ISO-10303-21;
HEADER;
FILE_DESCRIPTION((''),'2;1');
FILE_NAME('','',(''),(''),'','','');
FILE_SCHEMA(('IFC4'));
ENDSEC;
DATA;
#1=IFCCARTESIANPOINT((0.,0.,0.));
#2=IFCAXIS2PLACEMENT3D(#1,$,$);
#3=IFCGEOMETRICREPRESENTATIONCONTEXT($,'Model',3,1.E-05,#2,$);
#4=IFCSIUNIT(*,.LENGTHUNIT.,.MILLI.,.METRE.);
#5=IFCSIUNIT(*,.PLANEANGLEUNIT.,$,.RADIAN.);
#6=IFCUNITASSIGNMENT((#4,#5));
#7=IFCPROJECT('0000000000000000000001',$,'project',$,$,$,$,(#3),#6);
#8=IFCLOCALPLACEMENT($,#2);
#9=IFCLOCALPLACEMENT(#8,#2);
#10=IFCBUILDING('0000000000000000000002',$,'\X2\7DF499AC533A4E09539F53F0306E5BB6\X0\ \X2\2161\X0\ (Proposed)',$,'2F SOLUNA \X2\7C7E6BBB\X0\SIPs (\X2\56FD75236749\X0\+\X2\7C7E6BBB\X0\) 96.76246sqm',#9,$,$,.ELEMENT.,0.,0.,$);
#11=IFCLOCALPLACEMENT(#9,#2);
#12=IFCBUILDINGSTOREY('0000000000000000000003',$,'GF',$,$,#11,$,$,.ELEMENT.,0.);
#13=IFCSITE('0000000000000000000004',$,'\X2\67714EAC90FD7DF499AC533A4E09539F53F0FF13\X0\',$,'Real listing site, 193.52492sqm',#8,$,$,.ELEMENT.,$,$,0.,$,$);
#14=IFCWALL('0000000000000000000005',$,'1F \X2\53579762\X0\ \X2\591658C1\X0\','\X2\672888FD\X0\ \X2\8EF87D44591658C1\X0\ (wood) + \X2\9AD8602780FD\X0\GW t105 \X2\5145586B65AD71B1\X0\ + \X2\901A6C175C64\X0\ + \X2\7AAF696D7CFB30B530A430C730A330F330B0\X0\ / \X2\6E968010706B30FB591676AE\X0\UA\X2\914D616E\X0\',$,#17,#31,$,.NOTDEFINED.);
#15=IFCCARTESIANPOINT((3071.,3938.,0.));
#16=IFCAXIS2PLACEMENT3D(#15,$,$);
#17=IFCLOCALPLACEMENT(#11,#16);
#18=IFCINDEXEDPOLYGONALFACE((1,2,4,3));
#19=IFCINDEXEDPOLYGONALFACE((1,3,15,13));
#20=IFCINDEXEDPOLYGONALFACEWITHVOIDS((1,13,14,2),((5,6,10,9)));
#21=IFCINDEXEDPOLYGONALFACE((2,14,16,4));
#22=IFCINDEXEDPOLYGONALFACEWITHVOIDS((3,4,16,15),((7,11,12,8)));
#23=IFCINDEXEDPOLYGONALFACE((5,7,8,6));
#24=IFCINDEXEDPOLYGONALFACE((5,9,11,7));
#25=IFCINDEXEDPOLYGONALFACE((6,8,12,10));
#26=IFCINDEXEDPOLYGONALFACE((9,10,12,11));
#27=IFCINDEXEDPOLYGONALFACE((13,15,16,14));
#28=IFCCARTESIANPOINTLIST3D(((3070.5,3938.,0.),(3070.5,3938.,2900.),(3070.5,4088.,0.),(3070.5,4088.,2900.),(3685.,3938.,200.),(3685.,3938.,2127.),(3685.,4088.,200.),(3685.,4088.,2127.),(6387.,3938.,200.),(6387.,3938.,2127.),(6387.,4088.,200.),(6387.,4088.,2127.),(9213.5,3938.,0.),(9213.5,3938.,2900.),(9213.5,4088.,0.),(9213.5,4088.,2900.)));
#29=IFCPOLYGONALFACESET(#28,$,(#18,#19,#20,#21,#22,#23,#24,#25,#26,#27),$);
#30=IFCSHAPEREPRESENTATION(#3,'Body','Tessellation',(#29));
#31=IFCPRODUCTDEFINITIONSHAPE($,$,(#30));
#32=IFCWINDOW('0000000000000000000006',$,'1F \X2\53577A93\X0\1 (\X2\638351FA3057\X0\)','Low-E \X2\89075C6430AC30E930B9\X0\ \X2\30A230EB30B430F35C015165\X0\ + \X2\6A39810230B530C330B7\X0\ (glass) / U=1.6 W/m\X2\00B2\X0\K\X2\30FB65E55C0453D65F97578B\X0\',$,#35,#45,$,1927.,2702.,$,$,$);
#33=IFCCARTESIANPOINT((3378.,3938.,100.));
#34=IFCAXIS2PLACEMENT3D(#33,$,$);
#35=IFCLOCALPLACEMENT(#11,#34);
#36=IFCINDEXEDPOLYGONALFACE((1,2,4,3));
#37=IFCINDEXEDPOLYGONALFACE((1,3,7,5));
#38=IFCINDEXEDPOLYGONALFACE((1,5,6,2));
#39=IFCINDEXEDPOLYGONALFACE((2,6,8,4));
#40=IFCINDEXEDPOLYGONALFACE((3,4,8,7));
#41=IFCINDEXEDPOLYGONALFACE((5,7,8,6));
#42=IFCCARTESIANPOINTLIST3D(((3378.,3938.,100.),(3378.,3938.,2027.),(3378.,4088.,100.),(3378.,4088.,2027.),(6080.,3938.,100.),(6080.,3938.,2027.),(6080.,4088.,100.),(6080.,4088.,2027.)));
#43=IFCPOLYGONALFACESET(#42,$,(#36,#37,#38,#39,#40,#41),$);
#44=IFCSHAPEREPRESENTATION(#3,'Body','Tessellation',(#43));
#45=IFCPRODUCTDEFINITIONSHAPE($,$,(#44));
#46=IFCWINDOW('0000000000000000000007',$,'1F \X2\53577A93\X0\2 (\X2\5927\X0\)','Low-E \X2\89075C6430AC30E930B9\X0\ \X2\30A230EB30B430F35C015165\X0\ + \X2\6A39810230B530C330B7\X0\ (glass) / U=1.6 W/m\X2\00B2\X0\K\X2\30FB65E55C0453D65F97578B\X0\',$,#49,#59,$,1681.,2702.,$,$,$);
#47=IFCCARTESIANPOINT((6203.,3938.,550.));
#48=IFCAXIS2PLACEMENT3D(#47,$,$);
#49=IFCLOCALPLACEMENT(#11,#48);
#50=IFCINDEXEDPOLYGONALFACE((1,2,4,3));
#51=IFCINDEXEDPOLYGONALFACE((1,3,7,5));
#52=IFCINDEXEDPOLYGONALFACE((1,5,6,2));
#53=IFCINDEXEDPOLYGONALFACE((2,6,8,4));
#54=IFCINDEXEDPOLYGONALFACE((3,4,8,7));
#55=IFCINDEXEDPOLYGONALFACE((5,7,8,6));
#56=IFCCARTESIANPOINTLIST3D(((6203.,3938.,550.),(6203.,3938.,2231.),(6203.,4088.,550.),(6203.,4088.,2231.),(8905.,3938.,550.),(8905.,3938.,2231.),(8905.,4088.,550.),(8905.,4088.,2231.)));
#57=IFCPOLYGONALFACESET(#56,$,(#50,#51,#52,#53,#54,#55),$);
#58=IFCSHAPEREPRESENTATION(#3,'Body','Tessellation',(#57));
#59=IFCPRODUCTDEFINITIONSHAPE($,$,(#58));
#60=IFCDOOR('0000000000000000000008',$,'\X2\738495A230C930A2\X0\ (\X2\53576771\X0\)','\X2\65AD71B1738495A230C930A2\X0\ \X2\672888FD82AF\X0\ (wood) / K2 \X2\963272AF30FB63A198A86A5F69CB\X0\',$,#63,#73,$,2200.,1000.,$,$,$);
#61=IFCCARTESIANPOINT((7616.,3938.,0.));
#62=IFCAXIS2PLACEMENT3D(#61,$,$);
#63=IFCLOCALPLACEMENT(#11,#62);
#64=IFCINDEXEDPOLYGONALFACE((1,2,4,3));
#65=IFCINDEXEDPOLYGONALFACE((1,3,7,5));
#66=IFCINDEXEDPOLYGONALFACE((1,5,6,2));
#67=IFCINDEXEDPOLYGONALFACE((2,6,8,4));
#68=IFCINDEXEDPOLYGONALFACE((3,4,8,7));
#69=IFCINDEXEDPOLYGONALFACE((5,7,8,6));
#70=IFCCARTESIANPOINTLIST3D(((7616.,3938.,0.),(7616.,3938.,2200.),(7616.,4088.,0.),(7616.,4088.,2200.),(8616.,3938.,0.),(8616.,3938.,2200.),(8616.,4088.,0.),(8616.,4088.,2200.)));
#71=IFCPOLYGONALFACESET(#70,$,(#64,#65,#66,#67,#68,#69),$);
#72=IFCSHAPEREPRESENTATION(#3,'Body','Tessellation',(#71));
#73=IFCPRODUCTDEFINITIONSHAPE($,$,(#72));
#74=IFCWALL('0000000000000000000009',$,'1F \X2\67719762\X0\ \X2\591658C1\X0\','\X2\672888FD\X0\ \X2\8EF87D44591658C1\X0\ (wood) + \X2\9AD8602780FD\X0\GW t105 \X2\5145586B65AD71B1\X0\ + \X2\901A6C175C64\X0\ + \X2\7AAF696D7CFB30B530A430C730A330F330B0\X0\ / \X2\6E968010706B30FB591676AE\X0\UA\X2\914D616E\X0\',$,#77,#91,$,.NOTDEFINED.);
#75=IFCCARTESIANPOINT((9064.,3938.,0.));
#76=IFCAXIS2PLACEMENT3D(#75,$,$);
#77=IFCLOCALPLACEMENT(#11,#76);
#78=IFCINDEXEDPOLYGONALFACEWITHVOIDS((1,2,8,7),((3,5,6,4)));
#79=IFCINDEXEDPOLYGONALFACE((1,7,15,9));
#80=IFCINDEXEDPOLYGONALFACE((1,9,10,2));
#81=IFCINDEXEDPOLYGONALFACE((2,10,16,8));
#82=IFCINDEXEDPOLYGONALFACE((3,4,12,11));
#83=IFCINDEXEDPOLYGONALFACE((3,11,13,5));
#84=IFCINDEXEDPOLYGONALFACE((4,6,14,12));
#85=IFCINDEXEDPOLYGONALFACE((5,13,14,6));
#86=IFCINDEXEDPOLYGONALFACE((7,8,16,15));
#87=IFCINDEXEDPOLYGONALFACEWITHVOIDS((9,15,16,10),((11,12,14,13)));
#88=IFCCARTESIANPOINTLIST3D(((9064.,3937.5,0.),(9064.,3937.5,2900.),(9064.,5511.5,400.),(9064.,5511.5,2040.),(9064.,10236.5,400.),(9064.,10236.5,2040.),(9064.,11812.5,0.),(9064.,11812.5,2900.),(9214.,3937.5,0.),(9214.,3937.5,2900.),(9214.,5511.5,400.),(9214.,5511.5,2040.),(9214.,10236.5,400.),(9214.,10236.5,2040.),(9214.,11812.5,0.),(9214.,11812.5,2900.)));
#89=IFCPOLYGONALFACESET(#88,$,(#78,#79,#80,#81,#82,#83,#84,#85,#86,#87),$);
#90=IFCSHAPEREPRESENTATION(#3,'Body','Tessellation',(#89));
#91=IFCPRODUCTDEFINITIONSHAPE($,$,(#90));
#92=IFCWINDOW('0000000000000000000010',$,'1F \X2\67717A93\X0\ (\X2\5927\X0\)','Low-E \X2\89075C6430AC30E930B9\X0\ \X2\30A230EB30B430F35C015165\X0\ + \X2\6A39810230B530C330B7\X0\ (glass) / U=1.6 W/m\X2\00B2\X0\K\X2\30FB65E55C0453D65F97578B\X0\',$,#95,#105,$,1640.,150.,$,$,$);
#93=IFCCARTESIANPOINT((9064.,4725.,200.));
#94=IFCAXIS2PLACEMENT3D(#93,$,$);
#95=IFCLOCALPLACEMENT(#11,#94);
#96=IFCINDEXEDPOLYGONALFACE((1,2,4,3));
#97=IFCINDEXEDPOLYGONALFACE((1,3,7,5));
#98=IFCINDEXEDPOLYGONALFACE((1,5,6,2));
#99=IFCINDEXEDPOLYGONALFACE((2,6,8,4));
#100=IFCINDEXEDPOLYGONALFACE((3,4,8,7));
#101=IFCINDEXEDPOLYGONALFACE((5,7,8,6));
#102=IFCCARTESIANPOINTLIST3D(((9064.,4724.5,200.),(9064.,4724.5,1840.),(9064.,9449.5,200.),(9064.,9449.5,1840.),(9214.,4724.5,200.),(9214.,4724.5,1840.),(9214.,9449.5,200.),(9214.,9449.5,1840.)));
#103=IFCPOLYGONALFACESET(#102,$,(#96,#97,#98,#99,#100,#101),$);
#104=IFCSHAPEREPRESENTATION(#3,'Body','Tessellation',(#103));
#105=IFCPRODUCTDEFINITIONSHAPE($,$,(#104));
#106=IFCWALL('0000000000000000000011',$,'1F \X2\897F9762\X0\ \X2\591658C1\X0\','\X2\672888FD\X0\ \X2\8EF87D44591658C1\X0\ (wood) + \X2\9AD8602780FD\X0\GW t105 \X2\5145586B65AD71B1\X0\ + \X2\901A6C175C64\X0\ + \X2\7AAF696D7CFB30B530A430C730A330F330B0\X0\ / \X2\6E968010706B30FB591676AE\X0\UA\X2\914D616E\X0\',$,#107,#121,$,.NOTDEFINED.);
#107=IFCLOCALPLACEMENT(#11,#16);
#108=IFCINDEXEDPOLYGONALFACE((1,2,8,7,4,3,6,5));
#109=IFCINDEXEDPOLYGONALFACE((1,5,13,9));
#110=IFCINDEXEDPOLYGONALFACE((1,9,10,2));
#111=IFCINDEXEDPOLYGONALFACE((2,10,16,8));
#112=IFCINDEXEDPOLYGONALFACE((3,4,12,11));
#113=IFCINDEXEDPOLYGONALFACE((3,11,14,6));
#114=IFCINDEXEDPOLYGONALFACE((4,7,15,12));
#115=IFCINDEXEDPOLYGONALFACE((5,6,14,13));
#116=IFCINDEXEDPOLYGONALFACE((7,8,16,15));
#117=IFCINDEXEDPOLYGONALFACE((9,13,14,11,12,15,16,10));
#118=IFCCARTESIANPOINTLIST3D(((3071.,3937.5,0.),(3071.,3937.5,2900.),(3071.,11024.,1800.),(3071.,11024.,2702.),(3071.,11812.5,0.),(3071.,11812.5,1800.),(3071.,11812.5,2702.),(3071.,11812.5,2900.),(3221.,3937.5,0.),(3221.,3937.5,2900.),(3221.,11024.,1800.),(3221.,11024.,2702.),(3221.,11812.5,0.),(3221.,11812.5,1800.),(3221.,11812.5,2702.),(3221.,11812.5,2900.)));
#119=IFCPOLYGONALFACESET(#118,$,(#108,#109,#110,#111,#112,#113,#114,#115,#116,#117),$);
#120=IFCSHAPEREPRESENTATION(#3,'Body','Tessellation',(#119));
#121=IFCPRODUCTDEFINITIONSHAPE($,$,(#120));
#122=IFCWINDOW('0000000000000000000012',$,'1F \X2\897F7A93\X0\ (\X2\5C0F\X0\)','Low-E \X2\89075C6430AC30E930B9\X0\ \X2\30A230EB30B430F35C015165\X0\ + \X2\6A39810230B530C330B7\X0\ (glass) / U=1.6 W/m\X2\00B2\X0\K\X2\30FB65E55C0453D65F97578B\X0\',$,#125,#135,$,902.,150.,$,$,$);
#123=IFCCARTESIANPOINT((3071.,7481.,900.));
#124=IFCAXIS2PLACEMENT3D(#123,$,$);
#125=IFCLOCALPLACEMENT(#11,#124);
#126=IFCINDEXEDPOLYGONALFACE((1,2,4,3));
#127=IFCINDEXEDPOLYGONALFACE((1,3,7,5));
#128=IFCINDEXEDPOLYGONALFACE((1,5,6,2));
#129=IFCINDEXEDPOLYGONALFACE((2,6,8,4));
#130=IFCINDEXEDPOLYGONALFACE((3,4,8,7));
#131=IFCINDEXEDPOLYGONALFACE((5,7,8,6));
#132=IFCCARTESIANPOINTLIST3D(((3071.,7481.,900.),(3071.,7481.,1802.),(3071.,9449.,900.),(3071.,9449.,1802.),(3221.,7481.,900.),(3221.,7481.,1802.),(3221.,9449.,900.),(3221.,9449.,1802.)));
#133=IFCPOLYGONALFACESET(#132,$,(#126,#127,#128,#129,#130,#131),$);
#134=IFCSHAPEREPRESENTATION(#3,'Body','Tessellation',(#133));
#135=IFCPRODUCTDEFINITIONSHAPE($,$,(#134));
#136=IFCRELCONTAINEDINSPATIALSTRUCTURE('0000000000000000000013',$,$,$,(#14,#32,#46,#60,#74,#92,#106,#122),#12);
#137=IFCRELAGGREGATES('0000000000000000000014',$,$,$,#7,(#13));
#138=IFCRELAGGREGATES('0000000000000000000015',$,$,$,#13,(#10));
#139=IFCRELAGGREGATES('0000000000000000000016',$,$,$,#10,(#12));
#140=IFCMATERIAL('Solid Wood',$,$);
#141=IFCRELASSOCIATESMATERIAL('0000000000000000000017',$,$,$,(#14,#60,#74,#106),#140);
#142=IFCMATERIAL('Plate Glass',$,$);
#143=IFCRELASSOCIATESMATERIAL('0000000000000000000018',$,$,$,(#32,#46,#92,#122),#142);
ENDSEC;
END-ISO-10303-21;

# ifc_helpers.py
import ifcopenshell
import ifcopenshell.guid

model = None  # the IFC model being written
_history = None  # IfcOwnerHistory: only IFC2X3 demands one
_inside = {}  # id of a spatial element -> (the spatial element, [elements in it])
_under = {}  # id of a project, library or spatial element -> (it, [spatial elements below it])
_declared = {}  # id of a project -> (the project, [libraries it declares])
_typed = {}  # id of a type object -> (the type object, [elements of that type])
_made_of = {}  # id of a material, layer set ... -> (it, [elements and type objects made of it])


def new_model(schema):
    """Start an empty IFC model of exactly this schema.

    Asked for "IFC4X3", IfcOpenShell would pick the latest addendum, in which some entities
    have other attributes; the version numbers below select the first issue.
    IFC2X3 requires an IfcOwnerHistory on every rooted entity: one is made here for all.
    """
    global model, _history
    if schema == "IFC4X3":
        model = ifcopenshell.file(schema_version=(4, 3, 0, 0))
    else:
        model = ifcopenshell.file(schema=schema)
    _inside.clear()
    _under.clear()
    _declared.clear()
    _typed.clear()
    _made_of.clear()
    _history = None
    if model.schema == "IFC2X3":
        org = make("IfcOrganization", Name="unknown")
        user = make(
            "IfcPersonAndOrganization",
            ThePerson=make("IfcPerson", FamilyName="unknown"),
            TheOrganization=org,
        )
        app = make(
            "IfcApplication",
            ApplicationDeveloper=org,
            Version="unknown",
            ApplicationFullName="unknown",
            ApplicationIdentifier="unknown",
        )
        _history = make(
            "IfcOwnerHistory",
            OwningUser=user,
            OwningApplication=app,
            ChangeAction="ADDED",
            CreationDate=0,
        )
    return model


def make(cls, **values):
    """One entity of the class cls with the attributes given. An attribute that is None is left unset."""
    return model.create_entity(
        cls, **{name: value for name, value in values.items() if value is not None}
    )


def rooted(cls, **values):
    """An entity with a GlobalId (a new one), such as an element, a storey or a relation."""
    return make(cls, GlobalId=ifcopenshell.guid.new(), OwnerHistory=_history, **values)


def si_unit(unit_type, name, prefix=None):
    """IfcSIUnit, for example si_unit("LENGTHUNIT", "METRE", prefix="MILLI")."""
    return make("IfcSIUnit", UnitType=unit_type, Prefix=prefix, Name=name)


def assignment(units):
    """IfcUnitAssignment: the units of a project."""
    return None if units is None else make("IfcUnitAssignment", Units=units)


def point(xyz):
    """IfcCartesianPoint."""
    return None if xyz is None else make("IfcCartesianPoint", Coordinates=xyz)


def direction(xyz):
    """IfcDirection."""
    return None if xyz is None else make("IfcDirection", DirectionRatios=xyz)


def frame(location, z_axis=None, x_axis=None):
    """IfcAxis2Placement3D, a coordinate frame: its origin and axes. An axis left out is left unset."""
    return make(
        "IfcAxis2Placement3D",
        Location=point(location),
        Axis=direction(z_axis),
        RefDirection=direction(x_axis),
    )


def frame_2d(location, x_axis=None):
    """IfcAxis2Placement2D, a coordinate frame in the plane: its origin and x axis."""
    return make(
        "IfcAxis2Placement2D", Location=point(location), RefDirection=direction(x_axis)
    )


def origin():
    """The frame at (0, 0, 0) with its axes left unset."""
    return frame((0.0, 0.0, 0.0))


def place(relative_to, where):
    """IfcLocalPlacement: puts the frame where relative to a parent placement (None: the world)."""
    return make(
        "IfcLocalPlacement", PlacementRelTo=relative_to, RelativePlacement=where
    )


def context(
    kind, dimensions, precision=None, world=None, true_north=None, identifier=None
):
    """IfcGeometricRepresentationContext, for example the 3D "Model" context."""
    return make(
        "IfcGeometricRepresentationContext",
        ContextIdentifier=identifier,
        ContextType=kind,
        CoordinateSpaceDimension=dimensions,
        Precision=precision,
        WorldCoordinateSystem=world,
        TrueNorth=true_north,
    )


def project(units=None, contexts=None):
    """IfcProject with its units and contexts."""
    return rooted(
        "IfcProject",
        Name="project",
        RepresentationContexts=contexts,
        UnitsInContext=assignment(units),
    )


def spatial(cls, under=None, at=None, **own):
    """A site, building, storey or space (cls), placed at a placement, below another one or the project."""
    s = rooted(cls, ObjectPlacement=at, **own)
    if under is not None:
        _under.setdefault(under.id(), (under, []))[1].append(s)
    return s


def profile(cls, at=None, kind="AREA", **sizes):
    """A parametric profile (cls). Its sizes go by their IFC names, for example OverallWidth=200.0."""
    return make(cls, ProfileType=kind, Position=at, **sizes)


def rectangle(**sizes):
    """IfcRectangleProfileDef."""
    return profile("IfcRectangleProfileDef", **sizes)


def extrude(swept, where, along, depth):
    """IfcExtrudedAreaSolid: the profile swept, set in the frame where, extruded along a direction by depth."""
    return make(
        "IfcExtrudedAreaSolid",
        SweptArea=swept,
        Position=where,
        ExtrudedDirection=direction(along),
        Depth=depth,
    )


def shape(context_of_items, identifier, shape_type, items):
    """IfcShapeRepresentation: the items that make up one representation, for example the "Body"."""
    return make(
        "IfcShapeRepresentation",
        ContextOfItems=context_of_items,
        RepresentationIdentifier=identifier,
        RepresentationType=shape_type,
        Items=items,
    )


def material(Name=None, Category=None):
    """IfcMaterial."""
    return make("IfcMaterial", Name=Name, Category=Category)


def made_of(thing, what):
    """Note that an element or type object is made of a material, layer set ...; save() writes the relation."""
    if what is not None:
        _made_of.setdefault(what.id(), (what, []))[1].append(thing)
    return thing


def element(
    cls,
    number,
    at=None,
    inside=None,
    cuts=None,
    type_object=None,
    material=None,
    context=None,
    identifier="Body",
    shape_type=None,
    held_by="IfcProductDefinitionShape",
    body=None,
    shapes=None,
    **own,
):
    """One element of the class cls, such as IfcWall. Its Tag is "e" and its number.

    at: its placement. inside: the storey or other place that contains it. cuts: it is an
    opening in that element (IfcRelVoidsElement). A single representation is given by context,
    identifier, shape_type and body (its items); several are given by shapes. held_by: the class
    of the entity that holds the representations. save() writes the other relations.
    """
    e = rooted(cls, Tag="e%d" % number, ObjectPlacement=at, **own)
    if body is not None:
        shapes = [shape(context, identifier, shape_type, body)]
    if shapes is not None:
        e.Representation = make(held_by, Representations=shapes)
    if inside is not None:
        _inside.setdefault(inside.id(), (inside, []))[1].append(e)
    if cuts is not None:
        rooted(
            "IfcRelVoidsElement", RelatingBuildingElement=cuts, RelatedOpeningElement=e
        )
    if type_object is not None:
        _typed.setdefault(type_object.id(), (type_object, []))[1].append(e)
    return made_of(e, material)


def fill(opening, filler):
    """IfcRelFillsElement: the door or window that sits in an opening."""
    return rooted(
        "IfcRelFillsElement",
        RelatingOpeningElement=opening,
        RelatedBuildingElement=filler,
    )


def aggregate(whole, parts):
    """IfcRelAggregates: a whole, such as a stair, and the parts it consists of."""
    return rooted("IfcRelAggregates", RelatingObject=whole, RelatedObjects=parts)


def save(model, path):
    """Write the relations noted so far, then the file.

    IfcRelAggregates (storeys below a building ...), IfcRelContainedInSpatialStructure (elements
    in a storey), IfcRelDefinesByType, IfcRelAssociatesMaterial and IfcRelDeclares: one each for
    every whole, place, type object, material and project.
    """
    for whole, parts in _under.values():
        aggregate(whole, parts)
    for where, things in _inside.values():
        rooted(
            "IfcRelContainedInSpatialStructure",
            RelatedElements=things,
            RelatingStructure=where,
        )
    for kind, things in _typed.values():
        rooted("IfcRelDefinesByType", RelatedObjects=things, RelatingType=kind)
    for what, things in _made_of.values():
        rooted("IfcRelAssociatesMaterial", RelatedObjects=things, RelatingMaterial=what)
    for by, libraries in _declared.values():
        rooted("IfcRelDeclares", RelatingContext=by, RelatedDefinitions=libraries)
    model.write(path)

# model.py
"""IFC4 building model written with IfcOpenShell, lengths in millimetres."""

from ifc_helpers import new_model, si_unit, frame, frame_2d, origin, place, context, project, spatial, rectangle, extrude, material, element, fill, save


model = new_model("IFC4")

# Units and contexts
model_context = context("Model", 3, precision=1e-05, world=origin())
ifc_project = project(units=[si_unit("LENGTHUNIT", "METRE", prefix="MILLI"), si_unit("PLANEANGLEUNIT", "RADIAN")], contexts=[model_context])

# Site, building, storey
site_placement = place(None, origin())
site = spatial("IfcSite", under=ifc_project, at=site_placement, Name="東京都練馬区三原台３", ObjectType="Real listing site, 193.52492sqm", CompositionType="ELEMENT", RefElevation=0.0)
building_placement = place(site_placement, origin())
building = spatial("IfcBuilding", under=site, at=building_placement, Name="練馬区三原台の家 Ⅱ (Proposed)", ObjectType="2F SOLUNA 籾殻SIPs (国産杉+籾殻) 96.76246sqm", CompositionType="ELEMENT", ElevationOfRefHeight=0.0, ElevationOfTerrain=0.0)
storey_placement = place(building_placement, origin())
storey = spatial("IfcBuildingStorey", under=building, at=storey_placement, Name="GF", CompositionType="ELEMENT", Elevation=0.0)

# Shared definitions
ifc_material_1 = material(Name="Solid Wood")

# Wall, openings, windows, door
wall_1_placement = place(storey_placement, frame((3071.0, 3938.0, 0.0)))
wall_1 = element("IfcWall", 1, at=wall_1_placement, inside=storey, material=ifc_material_1, Name="1F 南面 外壁", Description="木製 軸組外壁 (wood) + 高性能GW t105 充填断熱 + 通気層 + 窯業系サイディング / 準耐火・外皮UA配慮", PredefinedType="NOTDEFINED", context=model_context, shape_type="SweptSolid", body=[
    extrude(rectangle(XDim=6143.0, YDim=150.0, at=frame_2d((3071.0, 75.0))), frame((3071.0, 3938.0, 0.0)), (0.0, 0.0, 1.0), 2900.0),
])
opening_1_placement = place(storey_placement, frame((3378.0, 3938.0, 100.0)))
opening_1 = element("IfcOpeningElement", 2, at=opening_1_placement, cuts=wall_1, PredefinedType="NOTDEFINED", context=model_context, shape_type="SweptSolid", body=[
    extrude(rectangle(XDim=2702.0, YDim=150.0, at=frame_2d((1351.0, 75.0))), frame((3378.0, 3938.0, 100.0)), (0.0, 0.0, 1.0), 1927.0),
])
opening_2_placement = place(storey_placement, frame((6203.0, 3938.0, 550.0)))
opening_2 = element("IfcOpeningElement", 3, at=opening_2_placement, cuts=wall_1, PredefinedType="NOTDEFINED", context=model_context, shape_type="SweptSolid", body=[
    extrude(rectangle(XDim=2702.0, YDim=150.0, at=frame_2d((1351.0, 75.0))), frame((6203.0, 3938.0, 550.0)), (0.0, 0.0, 1.0), 1681.0),
])
opening_3_placement = place(storey_placement, frame((7616.0, 3938.0, 0.0)))
opening_3 = element("IfcOpeningElement", 4, at=opening_3_placement, cuts=wall_1, PredefinedType="NOTDEFINED", context=model_context, shape_type="SweptSolid", body=[
    extrude(rectangle(XDim=1000.0, YDim=150.0, at=frame_2d((500.0, 75.0))), frame((7616.0, 3938.0, 0.0)), (0.0, 0.0, 1.0), 2200.0),
])
ifc_material_2 = material(Name="Plate Glass")
window_1_placement = place(storey_placement, frame((3378.0, 3938.0, 100.0)))
window_1 = element("IfcWindow", 5, at=window_1_placement, inside=storey, material=ifc_material_2, Name="1F 南窓1 (掃出し)", Description="Low-E 複層ガラス アルゴン封入 + 樹脂サッシ (glass) / U=1.6 W/m²K・日射取得型", OverallHeight=1927.0, OverallWidth=2702.0, context=model_context, shape_type="SweptSolid", body=[
    extrude(rectangle(XDim=2702.0, YDim=150.0, at=frame_2d((1351.0, 75.0))), frame((3378.0, 3938.0, 100.0)), (0.0, 0.0, 1.0), 1927.0),
])
fill(opening_1, window_1)
window_2_placement = place(storey_placement, frame((6203.0, 3938.0, 550.0)))
window_2 = element("IfcWindow", 6, at=window_2_placement, inside=storey, material=ifc_material_2, Name="1F 南窓2 (大)", Description="Low-E 複層ガラス アルゴン封入 + 樹脂サッシ (glass) / U=1.6 W/m²K・日射取得型", OverallHeight=1681.0, OverallWidth=2702.0, context=model_context, shape_type="SweptSolid", body=[
    extrude(rectangle(XDim=2702.0, YDim=150.0, at=frame_2d((1351.0, 75.0))), frame((6203.0, 3938.0, 550.0)), (0.0, 0.0, 1.0), 1681.0),
])
fill(opening_2, window_2)
door_placement = place(storey_placement, frame((7616.0, 3938.0, 0.0)))
door = element("IfcDoor", 7, at=door_placement, inside=storey, material=ifc_material_1, Name="玄関ドア (南東)", Description="断熱玄関ドア 木製芯 (wood) / K2 防犯・採風機構", OverallHeight=2200.0, OverallWidth=1000.0, context=model_context, shape_type="SweptSolid", body=[
    extrude(rectangle(XDim=1000.0, YDim=150.0, at=frame_2d((500.0, 75.0))), frame((7616.0, 3938.0, 0.0)), (0.0, 0.0, 1.0), 2200.0),
])
fill(opening_3, door)

# Walls, openings, windows
wall_2_placement = place(storey_placement, frame((9064.0, 3938.0, 0.0)))
wall_2 = element("IfcWall", 8, at=wall_2_placement, inside=storey, material=ifc_material_1, Name="1F 東面 外壁", Description="木製 軸組外壁 (wood) + 高性能GW t105 充填断熱 + 通気層 + 窯業系サイディング / 準耐火・外皮UA配慮", PredefinedType="NOTDEFINED", context=model_context, shape_type="SweptSolid", body=[
    extrude(rectangle(XDim=150.0, YDim=7875.0, at=frame_2d((75.0, 3937.0))), frame((9064.0, 3938.0, 0.0)), (0.0, 0.0, 1.0), 2900.0),
])
opening_4_placement = place(storey_placement, frame((9064.0, 4725.0, 200.0)))
opening_4 = element("IfcOpeningElement", 9, at=opening_4_placement, cuts=wall_2, PredefinedType="NOTDEFINED", context=model_context, shape_type="SweptSolid", body=[
    extrude(rectangle(XDim=150.0, YDim=4725.0, at=frame_2d((75.0, 2362.0))), frame((9064.0, 4725.0, 200.0)), (0.0, 0.0, 1.0), 1640.0),
])
window_3_placement = place(storey_placement, frame((9064.0, 4725.0, 200.0)))
window_3 = element("IfcWindow", 10, at=window_3_placement, inside=storey, material=ifc_material_2, Name="1F 東窓 (大)", Description="Low-E 複層ガラス アルゴン封入 + 樹脂サッシ (glass) / U=1.6 W/m²K・日射取得型", OverallHeight=1640.0, OverallWidth=150.0, context=model_context, shape_type="SweptSolid", body=[
    extrude(rectangle(XDim=150.0, YDim=4725.0, at=frame_2d((75.0, 2362.0))), frame((9064.0, 4725.0, 200.0)), (0.0, 0.0, 1.0), 1640.0),
])
fill(opening_4, window_3)
wall_3_placement = place(storey_placement, frame((3071.0, 3938.0, 0.0)))
wall_3 = element("IfcWall", 11, at=wall_3_placement, inside=storey, material=ifc_material_1, Name="1F 西面 外壁", Description="木製 軸組外壁 (wood) + 高性能GW t105 充填断熱 + 通気層 + 窯業系サイディング / 準耐火・外皮UA配慮", PredefinedType="NOTDEFINED", context=model_context, shape_type="SweptSolid", body=[
    extrude(rectangle(XDim=150.0, YDim=7875.0, at=frame_2d((75.0, 3937.0))), frame((3071.0, 3938.0, 0.0)), (0.0, 0.0, 1.0), 2900.0),
])
opening_5_placement = place(storey_placement, frame((3071.0, 7481.0, 900.0)))
opening_5 = element("IfcOpeningElement", 12, at=opening_5_placement, cuts=wall_3, PredefinedType="NOTDEFINED", context=model_context, shape_type="SweptSolid", body=[
    extrude(rectangle(XDim=150.0, YDim=1968.0, at=frame_2d((75.0, 984.0))), frame((3071.0, 7481.0, 900.0)), (0.0, 0.0, 1.0), 902.0),
])
window_4_placement = place(storey_placement, frame((3071.0, 7481.0, 900.0)))
window_4 = element("IfcWindow", 13, at=window_4_placement, inside=storey, material=ifc_material_2, Name="1F 西窓 (小)", Description="Low-E 複層ガラス アルゴン封入 + 樹脂サッシ (glass) / U=1.6 W/m²K・日射取得型", OverallHeight=902.0, OverallWidth=150.0, context=model_context, shape_type="SweptSolid", body=[
    extrude(rectangle(XDim=150.0, YDim=1968.0, at=frame_2d((75.0, 984.0))), frame((3071.0, 7481.0, 900.0)), (0.0, 0.0, 1.0), 902.0),
])
fill(opening_5, window_4)

save(model, "model.ifc")
